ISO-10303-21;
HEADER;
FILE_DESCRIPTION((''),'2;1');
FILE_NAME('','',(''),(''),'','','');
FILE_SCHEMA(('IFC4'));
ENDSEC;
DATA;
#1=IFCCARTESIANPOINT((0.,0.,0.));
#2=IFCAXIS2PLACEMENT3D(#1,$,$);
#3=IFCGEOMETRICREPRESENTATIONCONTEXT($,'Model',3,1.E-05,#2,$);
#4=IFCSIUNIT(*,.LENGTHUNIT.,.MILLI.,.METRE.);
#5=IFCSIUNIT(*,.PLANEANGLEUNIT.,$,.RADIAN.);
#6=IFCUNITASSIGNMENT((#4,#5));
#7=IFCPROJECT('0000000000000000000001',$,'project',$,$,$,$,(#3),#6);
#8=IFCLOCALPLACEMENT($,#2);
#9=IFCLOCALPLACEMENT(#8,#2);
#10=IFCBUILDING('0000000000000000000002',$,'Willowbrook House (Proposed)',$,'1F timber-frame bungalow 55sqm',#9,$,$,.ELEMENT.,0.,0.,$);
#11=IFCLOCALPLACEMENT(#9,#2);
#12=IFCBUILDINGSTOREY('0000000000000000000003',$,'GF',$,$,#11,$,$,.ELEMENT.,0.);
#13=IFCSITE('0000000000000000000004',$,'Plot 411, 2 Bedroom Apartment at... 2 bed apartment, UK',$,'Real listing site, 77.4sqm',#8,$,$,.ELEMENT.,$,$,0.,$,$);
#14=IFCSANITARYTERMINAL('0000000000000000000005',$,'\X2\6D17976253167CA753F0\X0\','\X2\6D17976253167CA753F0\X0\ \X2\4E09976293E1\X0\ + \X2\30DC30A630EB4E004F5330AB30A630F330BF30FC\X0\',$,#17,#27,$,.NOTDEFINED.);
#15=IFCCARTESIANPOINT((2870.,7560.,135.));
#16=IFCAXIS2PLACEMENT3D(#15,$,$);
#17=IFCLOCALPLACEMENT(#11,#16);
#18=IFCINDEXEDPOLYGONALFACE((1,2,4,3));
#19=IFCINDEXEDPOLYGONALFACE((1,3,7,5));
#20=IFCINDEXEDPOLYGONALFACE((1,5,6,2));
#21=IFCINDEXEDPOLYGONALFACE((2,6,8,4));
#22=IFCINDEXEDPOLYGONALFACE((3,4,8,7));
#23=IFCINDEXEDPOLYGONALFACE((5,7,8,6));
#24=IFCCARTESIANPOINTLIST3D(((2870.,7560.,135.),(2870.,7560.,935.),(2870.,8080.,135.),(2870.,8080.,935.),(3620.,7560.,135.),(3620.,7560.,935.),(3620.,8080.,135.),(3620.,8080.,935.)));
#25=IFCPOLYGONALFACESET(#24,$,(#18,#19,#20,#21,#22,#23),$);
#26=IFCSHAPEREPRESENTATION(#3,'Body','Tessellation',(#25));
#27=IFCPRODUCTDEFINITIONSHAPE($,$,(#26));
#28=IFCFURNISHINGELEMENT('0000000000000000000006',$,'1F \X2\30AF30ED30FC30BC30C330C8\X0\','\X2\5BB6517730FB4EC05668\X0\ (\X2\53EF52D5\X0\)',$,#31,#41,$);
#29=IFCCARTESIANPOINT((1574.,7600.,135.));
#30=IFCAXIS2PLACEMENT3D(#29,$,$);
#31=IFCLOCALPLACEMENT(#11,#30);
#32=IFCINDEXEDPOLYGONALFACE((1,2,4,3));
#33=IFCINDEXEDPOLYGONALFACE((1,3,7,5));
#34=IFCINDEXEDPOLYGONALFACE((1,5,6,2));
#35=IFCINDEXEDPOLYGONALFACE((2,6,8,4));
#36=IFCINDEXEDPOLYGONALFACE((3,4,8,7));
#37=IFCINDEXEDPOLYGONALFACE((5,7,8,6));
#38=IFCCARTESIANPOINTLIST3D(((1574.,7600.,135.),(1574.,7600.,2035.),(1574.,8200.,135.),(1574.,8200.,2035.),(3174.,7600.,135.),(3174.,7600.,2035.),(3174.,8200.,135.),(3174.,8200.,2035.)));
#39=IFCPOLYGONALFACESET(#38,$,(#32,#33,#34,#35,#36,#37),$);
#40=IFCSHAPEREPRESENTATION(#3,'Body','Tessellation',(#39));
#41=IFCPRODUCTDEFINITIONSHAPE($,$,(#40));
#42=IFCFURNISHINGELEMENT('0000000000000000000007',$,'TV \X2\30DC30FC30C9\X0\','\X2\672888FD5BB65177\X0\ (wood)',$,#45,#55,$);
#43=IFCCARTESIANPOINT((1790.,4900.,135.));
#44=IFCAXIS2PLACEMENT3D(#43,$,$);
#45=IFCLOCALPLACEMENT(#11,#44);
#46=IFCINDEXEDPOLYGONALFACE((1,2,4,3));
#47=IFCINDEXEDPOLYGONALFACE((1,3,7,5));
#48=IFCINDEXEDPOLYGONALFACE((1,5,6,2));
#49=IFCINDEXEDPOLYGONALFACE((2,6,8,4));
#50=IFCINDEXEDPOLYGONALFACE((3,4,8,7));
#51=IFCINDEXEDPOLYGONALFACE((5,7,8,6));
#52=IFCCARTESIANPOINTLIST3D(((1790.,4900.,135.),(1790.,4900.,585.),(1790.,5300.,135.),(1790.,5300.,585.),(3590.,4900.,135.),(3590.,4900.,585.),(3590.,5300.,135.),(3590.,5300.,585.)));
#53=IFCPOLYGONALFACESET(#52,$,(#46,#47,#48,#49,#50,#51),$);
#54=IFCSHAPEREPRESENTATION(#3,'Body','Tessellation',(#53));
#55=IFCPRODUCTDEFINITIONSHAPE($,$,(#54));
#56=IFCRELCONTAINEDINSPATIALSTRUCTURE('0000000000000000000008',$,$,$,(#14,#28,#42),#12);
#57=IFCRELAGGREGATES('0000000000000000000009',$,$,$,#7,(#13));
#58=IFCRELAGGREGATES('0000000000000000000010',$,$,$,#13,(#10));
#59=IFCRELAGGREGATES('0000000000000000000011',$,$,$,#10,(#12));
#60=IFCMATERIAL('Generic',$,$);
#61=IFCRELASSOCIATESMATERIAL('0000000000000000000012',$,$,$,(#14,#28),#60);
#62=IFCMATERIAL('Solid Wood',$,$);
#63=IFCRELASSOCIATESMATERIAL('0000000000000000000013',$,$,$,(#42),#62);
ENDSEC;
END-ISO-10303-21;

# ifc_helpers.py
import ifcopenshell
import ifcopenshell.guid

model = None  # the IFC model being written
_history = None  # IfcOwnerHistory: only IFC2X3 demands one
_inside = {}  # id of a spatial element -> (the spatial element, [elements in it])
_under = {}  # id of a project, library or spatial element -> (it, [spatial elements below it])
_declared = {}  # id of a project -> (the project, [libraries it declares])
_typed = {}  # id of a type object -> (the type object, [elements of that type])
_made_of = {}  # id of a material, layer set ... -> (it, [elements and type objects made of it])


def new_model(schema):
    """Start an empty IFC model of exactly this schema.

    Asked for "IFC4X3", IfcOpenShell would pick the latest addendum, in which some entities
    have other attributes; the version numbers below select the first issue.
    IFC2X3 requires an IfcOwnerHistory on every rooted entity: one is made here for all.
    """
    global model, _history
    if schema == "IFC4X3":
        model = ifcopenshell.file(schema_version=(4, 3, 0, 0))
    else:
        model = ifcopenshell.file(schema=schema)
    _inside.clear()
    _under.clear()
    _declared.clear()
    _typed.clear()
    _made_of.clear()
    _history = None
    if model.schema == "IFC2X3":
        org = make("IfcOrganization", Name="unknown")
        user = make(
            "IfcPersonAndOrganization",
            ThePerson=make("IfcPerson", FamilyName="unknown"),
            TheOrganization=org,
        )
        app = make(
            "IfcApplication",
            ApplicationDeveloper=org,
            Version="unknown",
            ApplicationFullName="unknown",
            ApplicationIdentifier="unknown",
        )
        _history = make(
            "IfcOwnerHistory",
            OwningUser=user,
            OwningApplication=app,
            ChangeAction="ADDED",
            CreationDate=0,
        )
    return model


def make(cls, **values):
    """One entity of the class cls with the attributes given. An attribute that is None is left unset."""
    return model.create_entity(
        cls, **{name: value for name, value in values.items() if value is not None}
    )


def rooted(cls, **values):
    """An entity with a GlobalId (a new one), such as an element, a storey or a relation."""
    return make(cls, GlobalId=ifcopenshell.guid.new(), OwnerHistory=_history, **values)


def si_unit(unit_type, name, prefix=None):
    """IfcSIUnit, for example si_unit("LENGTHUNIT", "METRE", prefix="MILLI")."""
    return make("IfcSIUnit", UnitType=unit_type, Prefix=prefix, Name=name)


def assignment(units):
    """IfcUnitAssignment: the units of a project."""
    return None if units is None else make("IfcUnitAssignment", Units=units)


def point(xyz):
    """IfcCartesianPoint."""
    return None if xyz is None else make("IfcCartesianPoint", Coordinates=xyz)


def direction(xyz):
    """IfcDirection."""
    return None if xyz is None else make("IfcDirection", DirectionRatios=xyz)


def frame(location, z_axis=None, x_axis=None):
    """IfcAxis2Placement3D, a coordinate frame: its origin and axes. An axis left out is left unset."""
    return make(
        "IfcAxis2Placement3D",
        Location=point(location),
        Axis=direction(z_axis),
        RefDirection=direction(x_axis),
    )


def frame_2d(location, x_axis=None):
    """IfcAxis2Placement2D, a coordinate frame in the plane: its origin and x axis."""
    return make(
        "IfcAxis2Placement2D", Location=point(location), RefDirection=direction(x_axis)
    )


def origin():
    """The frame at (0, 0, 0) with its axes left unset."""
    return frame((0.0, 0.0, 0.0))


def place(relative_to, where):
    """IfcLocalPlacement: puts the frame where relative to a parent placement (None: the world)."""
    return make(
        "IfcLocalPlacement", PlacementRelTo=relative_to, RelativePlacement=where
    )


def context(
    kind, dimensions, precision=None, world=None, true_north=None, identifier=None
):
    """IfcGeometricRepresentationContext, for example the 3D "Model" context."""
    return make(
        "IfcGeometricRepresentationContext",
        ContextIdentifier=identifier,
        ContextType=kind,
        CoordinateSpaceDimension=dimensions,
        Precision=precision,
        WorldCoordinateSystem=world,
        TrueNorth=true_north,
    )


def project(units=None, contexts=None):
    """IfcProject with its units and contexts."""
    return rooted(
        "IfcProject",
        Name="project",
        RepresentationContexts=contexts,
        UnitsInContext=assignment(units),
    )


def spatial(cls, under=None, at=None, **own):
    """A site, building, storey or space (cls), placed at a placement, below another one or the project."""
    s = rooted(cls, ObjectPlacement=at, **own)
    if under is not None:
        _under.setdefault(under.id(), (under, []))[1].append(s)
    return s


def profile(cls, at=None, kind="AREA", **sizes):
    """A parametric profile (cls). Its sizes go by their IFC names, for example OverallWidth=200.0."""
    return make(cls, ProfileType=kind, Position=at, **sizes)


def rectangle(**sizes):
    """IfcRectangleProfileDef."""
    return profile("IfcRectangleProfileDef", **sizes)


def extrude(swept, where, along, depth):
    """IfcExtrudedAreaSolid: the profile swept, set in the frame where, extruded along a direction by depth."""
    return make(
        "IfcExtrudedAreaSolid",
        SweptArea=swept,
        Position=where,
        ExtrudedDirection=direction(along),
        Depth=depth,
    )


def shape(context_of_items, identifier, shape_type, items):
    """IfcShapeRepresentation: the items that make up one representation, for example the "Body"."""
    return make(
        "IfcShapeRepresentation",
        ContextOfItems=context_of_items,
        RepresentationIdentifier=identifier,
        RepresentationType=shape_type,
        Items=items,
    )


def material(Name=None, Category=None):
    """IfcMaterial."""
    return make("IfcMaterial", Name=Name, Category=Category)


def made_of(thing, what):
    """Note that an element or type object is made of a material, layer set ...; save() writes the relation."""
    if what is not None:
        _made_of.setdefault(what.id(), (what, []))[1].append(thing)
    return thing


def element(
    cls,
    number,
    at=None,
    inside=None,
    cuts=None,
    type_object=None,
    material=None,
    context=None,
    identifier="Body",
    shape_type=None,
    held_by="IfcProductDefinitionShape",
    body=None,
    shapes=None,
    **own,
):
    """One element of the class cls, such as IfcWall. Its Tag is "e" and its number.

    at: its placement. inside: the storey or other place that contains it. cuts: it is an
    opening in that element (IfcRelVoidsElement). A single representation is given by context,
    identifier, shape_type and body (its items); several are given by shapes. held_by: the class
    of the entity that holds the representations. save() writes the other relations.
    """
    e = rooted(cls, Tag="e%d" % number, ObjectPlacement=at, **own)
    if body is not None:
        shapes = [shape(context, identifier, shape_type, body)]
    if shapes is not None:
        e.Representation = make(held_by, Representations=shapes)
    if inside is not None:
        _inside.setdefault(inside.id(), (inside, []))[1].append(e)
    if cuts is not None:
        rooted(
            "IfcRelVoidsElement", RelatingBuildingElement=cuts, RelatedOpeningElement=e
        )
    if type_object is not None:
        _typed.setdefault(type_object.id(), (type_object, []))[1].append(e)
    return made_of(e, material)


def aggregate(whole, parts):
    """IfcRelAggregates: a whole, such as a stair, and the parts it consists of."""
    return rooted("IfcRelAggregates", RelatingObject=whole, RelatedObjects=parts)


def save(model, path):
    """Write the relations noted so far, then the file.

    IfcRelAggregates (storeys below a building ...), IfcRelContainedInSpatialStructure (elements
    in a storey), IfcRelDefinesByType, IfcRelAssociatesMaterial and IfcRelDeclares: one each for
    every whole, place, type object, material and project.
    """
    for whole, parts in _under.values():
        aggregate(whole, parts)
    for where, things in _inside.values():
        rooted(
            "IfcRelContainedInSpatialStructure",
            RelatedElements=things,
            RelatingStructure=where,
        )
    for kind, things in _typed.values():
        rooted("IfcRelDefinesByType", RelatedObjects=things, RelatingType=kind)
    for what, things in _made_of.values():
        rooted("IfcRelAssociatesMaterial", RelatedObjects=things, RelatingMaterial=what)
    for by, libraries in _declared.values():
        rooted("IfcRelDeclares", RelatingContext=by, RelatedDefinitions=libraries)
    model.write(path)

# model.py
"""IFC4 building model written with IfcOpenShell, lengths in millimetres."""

from ifc_helpers import new_model, si_unit, frame, frame_2d, origin, place, context, project, spatial, rectangle, extrude, material, element, save


model = new_model("IFC4")

# Units and contexts
model_context = context("Model", 3, precision=1e-05, world=origin())
ifc_project = project(units=[si_unit("LENGTHUNIT", "METRE", prefix="MILLI"), si_unit("PLANEANGLEUNIT", "RADIAN")], contexts=[model_context])

# Site, building, storey
site_placement = place(None, origin())
site = spatial("IfcSite", under=ifc_project, at=site_placement, Name="Plot 411, 2 Bedroom Apartment at... 2 bed apartment, UK", ObjectType="Real listing site, 77.4sqm", CompositionType="ELEMENT", RefElevation=0.0)
building_placement = place(site_placement, origin())
building = spatial("IfcBuilding", under=site, at=building_placement, Name="Willowbrook House (Proposed)", ObjectType="1F timber-frame bungalow 55sqm", CompositionType="ELEMENT", ElevationOfRefHeight=0.0, ElevationOfTerrain=0.0)
storey_placement = place(building_placement, origin())
storey = spatial("IfcBuildingStorey", under=building, at=storey_placement, Name="GF", CompositionType="ELEMENT", Elevation=0.0)

# Shared definitions
ifc_material_1 = material(Name="Solid Wood")

# Shared definitions
ifc_material_2 = material(Name="Generic")

# Sanitary terminal
sanitary_terminal_1_placement = place(storey_placement, frame((2870.0, 7560.0, 135.0)))
element("IfcSanitaryTerminal", 1, at=sanitary_terminal_1_placement, inside=storey, material=ifc_material_2, Name="洗面化粧台", Description="洗面化粧台 三面鏡 + ボウル一体カウンター", PredefinedType="NOTDEFINED", context=model_context, shape_type="SweptSolid", body=[
    extrude(rectangle(XDim=750.0, YDim=520.0, at=frame_2d((375.0, 260.0))), frame((2870.0, 7560.0, 135.0)), (0.0, 0.0, 1.0), 800.0),
])

# Furnishing elements
furnishing_1_placement = place(storey_placement, frame((1574.0, 7600.0, 135.0)))
element("IfcFurnishingElement", 2, at=furnishing_1_placement, inside=storey, material=ifc_material_2, Name="1F クローゼット", Description="家具・什器 (可動)", context=model_context, shape_type="SweptSolid", body=[
    extrude(rectangle(XDim=1600.0, YDim=600.0, at=frame_2d((800.0, 300.0))), frame((1574.0, 7600.0, 135.0)), (0.0, 0.0, 1.0), 1900.0),
])
furnishing_2_placement = place(storey_placement, frame((1790.0, 4900.0, 135.0)))
element("IfcFurnishingElement", 3, at=furnishing_2_placement, inside=storey, material=ifc_material_1, Name="TV ボード", Description="木製家具 (wood)", context=model_context, shape_type="SweptSolid", body=[
    extrude(rectangle(XDim=1800.0, YDim=400.0, at=frame_2d((900.0, 200.0))), frame((1790.0, 4900.0, 135.0)), (0.0, 0.0, 1.0), 450.0),
])

save(model, "model.ifc")
